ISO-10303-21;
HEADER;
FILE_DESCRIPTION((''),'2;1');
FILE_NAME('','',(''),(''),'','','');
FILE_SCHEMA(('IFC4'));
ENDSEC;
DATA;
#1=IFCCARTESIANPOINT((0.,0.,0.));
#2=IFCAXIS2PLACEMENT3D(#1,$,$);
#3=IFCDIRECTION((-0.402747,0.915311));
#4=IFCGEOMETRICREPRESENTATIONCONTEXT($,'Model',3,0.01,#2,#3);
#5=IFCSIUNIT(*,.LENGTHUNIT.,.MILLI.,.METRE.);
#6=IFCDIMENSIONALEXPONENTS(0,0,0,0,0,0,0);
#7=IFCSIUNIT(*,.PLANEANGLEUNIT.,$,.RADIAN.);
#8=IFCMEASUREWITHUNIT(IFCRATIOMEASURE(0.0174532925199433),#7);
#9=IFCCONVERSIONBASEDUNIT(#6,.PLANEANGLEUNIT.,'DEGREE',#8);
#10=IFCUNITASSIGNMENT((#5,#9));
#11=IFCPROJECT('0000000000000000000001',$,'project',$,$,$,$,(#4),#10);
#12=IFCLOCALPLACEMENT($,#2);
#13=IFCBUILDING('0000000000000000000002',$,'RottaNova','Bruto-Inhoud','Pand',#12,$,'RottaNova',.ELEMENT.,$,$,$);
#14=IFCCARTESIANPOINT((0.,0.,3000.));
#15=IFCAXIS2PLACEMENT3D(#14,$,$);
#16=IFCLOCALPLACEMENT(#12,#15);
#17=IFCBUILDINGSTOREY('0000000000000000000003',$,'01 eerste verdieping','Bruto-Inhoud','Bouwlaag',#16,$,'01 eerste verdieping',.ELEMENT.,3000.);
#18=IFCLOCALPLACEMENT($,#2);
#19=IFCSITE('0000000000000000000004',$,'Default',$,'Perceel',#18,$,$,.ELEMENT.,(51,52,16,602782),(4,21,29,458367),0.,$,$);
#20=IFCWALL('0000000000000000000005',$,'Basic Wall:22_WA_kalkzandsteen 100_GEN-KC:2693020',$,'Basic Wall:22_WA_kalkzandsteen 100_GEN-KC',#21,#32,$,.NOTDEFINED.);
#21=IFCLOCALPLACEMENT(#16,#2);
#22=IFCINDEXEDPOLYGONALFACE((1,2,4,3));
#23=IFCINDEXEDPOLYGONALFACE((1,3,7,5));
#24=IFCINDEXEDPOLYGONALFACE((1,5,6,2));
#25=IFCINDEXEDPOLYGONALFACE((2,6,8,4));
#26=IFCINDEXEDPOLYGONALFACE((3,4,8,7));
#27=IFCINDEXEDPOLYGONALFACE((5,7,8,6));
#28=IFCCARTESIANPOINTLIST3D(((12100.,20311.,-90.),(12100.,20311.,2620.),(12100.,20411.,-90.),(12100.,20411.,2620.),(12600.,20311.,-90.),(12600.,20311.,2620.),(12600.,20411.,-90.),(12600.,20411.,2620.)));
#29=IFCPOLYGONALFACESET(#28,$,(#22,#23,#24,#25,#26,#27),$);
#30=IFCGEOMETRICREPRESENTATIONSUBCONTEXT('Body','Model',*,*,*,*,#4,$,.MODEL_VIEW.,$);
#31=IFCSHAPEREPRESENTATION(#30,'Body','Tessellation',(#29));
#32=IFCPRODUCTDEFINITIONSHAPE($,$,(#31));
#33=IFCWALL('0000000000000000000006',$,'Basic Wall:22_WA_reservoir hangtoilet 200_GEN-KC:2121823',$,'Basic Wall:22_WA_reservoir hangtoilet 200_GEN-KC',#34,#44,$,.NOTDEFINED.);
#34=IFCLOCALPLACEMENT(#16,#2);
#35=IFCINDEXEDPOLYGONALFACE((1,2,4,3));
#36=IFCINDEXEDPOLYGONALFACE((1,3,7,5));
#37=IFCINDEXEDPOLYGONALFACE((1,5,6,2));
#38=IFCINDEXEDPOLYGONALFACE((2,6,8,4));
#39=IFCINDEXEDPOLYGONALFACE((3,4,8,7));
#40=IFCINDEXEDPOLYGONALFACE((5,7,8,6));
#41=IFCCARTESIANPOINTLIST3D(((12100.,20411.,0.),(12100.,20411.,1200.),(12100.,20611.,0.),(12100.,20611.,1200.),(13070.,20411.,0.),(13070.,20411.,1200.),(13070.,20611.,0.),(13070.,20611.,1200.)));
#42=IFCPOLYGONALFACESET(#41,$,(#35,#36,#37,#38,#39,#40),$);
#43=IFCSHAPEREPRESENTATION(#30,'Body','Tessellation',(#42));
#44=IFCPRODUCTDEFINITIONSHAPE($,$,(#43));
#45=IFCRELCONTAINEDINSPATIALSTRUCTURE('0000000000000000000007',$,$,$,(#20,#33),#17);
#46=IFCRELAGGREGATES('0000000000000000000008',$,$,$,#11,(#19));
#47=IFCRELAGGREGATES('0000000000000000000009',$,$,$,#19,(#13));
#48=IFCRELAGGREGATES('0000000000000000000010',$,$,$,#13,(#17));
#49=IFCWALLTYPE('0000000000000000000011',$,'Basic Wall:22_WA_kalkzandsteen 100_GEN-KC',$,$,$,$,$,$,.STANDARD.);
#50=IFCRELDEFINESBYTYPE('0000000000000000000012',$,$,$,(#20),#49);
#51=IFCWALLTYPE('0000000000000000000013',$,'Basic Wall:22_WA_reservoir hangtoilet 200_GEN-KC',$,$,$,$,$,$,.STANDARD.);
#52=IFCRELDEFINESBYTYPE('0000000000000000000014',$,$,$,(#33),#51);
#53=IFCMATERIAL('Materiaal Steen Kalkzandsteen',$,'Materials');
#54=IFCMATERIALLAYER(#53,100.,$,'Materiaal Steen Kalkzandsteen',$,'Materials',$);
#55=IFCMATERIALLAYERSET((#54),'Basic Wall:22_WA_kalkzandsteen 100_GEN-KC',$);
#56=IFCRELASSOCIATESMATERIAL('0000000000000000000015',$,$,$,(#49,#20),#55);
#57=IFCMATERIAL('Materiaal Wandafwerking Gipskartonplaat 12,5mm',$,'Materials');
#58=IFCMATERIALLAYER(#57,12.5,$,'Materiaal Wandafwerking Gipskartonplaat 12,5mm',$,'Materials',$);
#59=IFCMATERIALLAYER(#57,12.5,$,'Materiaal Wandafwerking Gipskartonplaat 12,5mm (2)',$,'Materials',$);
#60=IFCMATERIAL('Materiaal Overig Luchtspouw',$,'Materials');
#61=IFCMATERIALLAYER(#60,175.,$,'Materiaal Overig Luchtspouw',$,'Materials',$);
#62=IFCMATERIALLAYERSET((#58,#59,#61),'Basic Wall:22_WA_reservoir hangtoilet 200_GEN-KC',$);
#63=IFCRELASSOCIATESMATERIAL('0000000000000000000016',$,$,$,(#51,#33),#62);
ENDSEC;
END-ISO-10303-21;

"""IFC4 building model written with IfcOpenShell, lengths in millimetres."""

from ifc_helpers import new_model, entity, si_unit, converted_unit, direction, frame, frame_2d, origin, place, context, subcontext, project, spatial, rectangle, extrude, material, layer, layer_set, type_object, element, save


model = new_model("IFC4")

# Units and contexts
model_context = context("Model", 3, precision=0.01, world=origin(), true_north=direction((-0.402747, 0.915311)))
body_context = subcontext(model_context, "Body", "Model", "MODEL_VIEW")
ifc_project = project(units=[si_unit("LENGTHUNIT", "METRE", prefix="MILLI"), converted_unit("PLANEANGLEUNIT", "DEGREE", entity("IfcRatioMeasure", 0.0174532925199433), si_unit("PLANEANGLEUNIT", "RADIAN"), dimensions=[0, 0, 0, 0, 0, 0, 0])], contexts=[model_context])

# Site, building, storey
site_placement = place(None, origin())
site = spatial("IfcSite", under=ifc_project, at=site_placement, Name="Default", ObjectType="Perceel", CompositionType="ELEMENT", RefLatitude=(51, 52, 16, 602782), RefLongitude=(4, 21, 29, 458367), RefElevation=0.0)
building_placement = place(None, origin())
building = spatial("IfcBuilding", under=site, at=building_placement, Name="RottaNova", Description="Bruto-Inhoud", ObjectType="Pand", LongName="RottaNova", CompositionType="ELEMENT")
storey_placement = place(building_placement, frame((0.0, 0.0, 3000.0)))
storey = spatial("IfcBuildingStorey", under=building, at=storey_placement, Name="01 eerste verdieping", Description="Bruto-Inhoud", ObjectType="Bouwlaag", LongName="01 eerste verdieping", CompositionType="ELEMENT", Elevation=3000.0)

# Shared definitions
ifc_material_1 = material(Name="Materiaal Steen Kalkzandsteen", Category="Materials")

# Walls
ifc_layer_1 = layer(ifc_material_1, 100.0, Name="Materiaal Steen Kalkzandsteen", Category="Materials")
ifc_layer_set_1 = layer_set([ifc_layer_1], Name="Basic Wall:22_WA_kalkzandsteen 100_GEN-KC")
wall_type_1 = type_object("IfcWallType", Name="Basic Wall:22_WA_kalkzandsteen 100_GEN-KC", PredefinedType="STANDARD", material=ifc_layer_set_1)
wall_1_placement = place(storey_placement, frame((12600.0, 20361.0, -90.0), z_axis=(0.0, 0.0, 1.0), x_axis=(-1.0, 0.0, 0.0)))
element("IfcWall", 1, at=wall_1_placement, inside=storey, type_object=wall_type_1, material=ifc_layer_set_1, Name="Basic Wall:22_WA_kalkzandsteen 100_GEN-KC:2693020", ObjectType="Basic Wall:22_WA_kalkzandsteen 100_GEN-KC", PredefinedType="NOTDEFINED", context=body_context, shape_type="SweptSolid", body=[
    extrude(rectangle(XDim=500.0, YDim=100.0, at=frame_2d((250.0, 0.0), x_axis=(-1.0, 0.0))), origin(), (0.0, 0.0, 1.0), 2710.0),
])
ifc_material_2 = material(Name="Materiaal Wandafwerking Gipskartonplaat 12,5mm", Category="Materials")
ifc_layer_2 = layer(ifc_material_2, 12.5, Name="Materiaal Wandafwerking Gipskartonplaat 12,5mm", Category="Materials")
ifc_layer_3 = layer(ifc_material_2, 12.5, Name="Materiaal Wandafwerking Gipskartonplaat 12,5mm (2)", Category="Materials")
ifc_material_3 = material(Name="Materiaal Overig Luchtspouw", Category="Materials")
ifc_layer_4 = layer(ifc_material_3, 175.0, Name="Materiaal Overig Luchtspouw", Category="Materials")
ifc_layer_set_2 = layer_set([ifc_layer_2, ifc_layer_3, ifc_layer_4], Name="Basic Wall:22_WA_reservoir hangtoilet 200_GEN-KC")
wall_type_2 = type_object("IfcWallType", Name="Basic Wall:22_WA_reservoir hangtoilet 200_GEN-KC", PredefinedType="STANDARD", material=ifc_layer_set_2)
wall_2_placement = place(storey_placement, frame((13070.0, 20511.0, 0.0), z_axis=(0.0, 0.0, 1.0), x_axis=(-1.0, 0.0, 0.0)))
element("IfcWall", 2, at=wall_2_placement, inside=storey, type_object=wall_type_2, material=ifc_layer_set_2, Name="Basic Wall:22_WA_reservoir hangtoilet 200_GEN-KC:2121823", ObjectType="Basic Wall:22_WA_reservoir hangtoilet 200_GEN-KC", PredefinedType="NOTDEFINED", context=body_context, shape_type="SweptSolid", body=[
    extrude(rectangle(XDim=970.0, YDim=200.0, at=frame_2d((485.0, 0.0), x_axis=(-1.0, 0.0))), origin(), (0.0, 0.0, 1.0), 1200.0),
])

save(model, "model.ifc")
